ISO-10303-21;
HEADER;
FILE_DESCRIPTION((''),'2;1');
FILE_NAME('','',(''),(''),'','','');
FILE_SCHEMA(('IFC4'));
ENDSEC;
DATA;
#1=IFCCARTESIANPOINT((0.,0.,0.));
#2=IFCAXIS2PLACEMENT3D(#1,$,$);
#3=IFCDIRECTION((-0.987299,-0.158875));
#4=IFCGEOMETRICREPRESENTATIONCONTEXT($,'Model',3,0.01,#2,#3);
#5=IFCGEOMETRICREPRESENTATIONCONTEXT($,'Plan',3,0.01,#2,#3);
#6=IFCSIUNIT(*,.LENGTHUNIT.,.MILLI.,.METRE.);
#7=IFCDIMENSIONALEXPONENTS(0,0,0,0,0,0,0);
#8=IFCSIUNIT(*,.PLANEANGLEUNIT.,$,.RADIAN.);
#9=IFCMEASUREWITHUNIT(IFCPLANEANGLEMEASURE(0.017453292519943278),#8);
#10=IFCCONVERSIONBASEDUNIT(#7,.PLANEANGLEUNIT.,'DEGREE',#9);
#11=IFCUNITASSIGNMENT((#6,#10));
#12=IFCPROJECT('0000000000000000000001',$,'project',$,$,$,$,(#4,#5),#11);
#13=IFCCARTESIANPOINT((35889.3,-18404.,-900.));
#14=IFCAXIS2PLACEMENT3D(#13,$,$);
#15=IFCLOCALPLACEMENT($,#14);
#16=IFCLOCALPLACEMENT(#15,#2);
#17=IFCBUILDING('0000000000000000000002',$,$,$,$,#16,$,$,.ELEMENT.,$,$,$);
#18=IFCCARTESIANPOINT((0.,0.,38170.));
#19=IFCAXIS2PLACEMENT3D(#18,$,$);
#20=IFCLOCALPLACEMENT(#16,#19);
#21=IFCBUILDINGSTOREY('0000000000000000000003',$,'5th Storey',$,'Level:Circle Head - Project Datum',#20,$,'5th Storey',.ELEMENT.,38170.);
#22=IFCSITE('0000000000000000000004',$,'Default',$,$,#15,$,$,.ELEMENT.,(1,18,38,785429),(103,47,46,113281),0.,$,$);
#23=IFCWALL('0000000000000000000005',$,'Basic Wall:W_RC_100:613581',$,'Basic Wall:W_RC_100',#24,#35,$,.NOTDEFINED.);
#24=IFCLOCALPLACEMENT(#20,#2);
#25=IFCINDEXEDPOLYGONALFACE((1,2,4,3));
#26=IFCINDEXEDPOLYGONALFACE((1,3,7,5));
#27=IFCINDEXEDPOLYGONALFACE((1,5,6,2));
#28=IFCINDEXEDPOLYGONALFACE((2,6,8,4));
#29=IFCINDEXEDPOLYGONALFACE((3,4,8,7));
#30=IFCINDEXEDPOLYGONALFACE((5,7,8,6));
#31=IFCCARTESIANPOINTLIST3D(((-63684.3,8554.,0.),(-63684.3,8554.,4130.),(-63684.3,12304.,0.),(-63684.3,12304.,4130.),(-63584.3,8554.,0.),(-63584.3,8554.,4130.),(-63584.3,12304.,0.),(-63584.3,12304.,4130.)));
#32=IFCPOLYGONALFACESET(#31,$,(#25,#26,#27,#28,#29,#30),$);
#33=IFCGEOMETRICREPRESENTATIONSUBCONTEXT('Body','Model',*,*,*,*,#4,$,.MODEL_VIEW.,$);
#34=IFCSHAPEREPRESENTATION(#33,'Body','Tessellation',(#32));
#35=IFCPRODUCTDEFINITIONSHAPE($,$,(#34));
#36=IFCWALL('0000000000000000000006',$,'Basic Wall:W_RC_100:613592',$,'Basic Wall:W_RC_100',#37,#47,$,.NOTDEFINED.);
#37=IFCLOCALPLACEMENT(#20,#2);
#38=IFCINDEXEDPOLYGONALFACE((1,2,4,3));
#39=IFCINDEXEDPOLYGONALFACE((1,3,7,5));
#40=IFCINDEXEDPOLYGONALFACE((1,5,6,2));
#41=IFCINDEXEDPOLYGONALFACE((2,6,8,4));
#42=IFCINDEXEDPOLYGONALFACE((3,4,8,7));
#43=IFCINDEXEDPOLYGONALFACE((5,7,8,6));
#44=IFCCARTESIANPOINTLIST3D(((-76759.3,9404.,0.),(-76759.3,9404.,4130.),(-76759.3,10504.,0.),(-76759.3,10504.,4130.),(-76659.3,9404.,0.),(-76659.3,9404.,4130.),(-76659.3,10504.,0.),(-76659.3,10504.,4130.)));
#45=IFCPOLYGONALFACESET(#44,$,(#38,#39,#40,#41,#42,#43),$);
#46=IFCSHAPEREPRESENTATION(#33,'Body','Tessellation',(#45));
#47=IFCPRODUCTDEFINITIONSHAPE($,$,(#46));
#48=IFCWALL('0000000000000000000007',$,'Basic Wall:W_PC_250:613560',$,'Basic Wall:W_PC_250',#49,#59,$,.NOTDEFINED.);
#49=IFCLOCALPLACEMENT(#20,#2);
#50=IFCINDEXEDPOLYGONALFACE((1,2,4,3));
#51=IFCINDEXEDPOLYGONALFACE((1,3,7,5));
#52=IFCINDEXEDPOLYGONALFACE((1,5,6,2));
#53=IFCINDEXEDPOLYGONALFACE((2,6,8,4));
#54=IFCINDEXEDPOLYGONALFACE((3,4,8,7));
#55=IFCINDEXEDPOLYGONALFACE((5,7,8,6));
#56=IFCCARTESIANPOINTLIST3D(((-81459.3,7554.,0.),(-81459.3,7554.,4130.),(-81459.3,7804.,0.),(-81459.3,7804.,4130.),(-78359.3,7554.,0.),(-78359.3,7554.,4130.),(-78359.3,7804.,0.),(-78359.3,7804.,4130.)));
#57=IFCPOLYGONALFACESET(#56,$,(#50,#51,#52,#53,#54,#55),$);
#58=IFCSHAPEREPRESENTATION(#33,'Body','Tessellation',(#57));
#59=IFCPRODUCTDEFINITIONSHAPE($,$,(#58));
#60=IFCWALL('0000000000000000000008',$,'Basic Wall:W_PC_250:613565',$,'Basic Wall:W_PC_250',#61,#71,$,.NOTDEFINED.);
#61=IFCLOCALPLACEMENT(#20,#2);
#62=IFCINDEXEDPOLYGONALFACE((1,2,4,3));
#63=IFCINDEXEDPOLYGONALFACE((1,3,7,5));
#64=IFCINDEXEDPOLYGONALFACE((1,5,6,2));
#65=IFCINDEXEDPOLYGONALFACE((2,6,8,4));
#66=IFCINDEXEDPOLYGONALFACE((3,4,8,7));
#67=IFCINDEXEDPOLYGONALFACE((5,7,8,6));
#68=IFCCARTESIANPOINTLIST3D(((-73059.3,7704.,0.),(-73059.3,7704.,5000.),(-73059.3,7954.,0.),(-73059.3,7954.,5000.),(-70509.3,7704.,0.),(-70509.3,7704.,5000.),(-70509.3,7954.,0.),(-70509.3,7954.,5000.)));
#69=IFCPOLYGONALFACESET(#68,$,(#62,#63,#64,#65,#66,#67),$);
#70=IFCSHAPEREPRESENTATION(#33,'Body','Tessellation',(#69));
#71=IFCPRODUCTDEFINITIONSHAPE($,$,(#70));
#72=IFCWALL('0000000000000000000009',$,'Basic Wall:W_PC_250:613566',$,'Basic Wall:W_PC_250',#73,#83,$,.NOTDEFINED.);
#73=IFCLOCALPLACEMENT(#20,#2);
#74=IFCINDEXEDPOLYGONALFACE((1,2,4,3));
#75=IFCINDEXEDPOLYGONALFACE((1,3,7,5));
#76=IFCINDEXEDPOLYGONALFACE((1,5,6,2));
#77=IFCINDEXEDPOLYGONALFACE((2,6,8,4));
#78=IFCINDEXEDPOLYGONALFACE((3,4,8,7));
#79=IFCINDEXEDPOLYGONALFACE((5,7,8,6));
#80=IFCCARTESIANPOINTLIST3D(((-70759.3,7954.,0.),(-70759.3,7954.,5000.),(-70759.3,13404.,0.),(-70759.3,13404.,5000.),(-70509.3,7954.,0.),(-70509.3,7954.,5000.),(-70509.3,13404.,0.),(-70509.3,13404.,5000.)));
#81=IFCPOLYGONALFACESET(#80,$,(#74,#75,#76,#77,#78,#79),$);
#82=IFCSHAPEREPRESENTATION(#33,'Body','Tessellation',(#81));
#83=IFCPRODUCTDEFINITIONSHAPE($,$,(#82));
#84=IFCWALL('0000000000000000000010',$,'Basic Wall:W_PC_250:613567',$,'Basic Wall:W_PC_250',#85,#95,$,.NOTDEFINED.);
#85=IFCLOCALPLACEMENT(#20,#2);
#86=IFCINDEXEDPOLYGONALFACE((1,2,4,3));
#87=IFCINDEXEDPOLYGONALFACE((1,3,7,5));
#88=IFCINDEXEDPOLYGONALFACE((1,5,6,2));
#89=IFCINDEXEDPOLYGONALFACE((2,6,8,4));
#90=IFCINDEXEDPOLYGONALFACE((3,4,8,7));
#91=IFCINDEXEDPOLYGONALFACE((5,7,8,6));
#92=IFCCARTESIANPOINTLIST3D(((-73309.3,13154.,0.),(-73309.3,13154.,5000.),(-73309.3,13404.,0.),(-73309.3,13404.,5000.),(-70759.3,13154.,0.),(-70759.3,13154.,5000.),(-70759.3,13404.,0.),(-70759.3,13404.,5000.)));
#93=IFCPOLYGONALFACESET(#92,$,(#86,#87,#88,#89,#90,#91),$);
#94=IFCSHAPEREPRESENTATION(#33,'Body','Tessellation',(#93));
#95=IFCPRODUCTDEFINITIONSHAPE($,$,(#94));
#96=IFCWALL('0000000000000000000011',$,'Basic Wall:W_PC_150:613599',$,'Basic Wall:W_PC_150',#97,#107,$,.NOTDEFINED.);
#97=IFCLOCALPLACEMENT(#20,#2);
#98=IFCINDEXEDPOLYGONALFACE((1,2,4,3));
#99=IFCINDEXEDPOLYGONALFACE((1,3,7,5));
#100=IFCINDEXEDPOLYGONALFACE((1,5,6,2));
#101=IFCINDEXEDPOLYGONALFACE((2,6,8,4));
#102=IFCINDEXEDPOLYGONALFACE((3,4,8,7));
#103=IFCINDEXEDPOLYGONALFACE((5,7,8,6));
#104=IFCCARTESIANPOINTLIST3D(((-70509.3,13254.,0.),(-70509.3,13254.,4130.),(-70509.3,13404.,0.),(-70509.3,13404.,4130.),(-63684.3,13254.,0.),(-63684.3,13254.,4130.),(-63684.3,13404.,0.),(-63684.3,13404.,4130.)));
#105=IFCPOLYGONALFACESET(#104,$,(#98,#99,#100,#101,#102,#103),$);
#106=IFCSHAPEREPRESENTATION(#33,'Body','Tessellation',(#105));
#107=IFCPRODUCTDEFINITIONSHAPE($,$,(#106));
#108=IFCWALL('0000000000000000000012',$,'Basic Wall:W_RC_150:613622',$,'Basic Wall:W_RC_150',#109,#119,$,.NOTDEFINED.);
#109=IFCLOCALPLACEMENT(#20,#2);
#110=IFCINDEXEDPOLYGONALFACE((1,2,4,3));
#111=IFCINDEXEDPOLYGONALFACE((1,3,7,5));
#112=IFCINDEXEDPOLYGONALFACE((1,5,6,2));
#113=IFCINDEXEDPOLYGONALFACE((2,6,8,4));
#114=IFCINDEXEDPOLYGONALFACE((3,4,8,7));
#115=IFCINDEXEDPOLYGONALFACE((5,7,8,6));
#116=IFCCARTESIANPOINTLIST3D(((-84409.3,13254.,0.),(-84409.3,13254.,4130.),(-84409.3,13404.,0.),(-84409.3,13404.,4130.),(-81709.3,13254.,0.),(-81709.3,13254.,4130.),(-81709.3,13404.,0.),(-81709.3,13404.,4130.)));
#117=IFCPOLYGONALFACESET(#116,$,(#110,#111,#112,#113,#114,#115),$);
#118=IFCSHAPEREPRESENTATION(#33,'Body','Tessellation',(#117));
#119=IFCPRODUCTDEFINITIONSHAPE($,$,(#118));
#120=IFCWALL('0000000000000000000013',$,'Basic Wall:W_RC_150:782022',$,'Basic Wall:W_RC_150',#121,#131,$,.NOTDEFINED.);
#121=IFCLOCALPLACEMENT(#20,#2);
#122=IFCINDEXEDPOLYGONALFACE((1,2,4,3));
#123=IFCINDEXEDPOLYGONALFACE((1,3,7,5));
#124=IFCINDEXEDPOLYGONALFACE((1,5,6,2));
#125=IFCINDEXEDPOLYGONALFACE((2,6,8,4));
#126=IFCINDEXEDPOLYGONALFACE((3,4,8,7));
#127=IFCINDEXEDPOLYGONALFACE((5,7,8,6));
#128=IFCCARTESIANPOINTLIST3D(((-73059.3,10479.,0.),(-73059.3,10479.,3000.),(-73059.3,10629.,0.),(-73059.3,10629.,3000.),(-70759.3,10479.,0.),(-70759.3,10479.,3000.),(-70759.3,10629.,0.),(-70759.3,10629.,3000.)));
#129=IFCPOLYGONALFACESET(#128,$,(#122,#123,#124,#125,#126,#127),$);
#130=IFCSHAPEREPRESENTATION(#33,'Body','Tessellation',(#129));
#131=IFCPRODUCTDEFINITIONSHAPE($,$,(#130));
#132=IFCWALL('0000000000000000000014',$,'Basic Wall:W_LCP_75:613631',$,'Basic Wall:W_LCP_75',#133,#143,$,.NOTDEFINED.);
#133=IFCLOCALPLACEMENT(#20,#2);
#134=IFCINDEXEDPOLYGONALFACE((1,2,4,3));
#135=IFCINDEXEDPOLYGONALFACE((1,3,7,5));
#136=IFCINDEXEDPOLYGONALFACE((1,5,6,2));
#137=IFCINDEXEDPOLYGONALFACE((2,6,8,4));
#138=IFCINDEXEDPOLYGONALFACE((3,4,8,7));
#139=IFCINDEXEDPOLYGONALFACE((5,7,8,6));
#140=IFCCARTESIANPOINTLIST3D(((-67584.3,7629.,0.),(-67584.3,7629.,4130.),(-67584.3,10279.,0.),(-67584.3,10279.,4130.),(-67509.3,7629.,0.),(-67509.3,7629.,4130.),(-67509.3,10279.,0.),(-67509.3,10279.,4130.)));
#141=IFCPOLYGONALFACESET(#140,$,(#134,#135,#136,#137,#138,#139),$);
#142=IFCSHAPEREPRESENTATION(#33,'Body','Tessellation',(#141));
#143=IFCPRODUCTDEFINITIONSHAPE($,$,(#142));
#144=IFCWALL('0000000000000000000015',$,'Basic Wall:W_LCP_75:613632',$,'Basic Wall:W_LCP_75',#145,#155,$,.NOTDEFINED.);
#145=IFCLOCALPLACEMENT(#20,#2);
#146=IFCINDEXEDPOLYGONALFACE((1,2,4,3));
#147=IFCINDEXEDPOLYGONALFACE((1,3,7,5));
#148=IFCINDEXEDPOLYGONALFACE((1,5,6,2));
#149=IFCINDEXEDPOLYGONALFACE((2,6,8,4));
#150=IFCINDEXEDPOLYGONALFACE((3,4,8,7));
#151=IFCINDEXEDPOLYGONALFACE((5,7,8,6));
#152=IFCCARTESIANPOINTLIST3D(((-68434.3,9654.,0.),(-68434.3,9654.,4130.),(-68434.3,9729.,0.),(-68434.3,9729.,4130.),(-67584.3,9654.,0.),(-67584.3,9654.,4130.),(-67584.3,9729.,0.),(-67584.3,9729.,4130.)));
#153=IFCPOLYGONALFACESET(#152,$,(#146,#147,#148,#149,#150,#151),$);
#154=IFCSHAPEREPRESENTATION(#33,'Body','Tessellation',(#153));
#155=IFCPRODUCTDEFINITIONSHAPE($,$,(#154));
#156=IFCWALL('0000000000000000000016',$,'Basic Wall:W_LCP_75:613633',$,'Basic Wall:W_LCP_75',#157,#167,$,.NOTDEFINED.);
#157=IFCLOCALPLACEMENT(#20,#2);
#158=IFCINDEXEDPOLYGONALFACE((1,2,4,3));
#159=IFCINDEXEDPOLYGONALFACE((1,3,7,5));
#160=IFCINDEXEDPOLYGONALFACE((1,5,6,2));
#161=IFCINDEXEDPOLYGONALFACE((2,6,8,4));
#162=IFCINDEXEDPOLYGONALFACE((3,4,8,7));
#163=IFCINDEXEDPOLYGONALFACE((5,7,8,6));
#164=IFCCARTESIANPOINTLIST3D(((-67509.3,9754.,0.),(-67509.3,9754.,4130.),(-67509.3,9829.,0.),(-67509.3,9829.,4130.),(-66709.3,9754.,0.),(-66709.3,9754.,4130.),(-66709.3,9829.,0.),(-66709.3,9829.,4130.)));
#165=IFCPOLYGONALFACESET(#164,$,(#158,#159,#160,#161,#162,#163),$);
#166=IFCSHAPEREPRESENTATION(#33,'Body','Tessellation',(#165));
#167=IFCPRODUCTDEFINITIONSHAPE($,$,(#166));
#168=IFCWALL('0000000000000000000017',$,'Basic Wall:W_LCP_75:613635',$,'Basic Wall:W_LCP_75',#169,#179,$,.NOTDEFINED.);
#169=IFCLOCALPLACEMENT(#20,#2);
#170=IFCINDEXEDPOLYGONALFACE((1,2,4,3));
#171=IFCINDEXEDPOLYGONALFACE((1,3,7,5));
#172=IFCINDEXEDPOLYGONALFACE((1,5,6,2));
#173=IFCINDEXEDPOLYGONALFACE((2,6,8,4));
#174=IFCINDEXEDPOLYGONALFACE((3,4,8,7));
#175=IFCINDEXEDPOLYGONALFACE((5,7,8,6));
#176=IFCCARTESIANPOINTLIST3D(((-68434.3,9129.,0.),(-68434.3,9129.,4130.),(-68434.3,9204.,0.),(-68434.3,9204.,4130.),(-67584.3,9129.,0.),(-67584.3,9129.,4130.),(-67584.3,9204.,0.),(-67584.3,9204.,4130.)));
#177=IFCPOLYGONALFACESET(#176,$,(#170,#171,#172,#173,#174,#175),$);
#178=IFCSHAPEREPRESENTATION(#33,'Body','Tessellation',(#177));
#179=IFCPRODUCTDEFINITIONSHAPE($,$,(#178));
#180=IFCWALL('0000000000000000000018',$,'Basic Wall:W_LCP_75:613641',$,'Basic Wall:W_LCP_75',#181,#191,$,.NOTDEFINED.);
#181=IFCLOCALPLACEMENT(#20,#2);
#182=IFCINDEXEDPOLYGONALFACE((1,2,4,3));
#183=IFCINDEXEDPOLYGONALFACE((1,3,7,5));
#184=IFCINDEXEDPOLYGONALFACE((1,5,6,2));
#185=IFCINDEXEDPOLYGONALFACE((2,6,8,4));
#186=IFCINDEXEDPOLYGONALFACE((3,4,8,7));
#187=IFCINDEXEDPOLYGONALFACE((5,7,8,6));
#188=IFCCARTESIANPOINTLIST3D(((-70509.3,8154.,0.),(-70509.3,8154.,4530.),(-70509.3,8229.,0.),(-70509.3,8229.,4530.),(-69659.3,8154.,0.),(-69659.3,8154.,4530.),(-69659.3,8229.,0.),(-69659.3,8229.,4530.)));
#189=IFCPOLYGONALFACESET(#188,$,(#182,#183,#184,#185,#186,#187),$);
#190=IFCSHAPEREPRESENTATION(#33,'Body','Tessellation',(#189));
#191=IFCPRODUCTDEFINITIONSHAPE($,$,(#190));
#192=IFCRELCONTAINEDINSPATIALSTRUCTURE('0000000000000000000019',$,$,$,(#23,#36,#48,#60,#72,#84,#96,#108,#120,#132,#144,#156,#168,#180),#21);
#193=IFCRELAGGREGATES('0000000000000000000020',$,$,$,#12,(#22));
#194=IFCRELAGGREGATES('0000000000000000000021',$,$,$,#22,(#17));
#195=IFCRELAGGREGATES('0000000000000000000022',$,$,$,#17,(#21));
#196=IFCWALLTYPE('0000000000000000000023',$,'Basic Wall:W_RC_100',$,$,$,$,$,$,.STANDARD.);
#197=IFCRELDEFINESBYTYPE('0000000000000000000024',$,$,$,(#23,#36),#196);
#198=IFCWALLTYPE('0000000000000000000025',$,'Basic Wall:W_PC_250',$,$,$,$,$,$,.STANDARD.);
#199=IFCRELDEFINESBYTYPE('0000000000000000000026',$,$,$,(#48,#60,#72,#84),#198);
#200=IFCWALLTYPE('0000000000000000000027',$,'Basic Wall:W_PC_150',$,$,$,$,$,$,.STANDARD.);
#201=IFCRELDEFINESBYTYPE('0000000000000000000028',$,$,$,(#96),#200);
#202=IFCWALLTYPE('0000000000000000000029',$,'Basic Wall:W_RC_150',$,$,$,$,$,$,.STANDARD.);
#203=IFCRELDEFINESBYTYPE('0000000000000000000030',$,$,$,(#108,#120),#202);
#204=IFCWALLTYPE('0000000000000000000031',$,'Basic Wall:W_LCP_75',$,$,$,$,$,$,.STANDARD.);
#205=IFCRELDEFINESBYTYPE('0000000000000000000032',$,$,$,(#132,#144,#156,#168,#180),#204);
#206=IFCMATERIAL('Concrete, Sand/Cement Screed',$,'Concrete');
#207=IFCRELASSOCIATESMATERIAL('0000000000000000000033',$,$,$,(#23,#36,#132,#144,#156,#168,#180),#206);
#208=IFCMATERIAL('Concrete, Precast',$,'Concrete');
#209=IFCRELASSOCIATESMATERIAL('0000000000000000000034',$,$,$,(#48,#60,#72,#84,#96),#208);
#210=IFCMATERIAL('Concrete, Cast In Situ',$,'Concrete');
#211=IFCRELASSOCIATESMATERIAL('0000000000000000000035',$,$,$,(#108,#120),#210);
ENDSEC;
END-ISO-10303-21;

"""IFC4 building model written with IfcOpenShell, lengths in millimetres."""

from ifc_helpers import new_model, entity, si_unit, converted_unit, direction, frame, origin, place, context, subcontext, project, spatial, indexed_curve, outline, extrude, material, type_object, element, save


model = new_model("IFC4")

# Units and contexts
model_context = context("Model", 3, precision=0.01, world=origin(), true_north=direction((-0.987299, -0.158875)))
plan_context = context("Plan", 3, precision=0.01, world=origin(), true_north=direction((-0.987299, -0.158875)))
body_context = subcontext(model_context, "Body", "Model", "MODEL_VIEW")
ifc_project = project(units=[si_unit("LENGTHUNIT", "METRE", prefix="MILLI"), converted_unit("PLANEANGLEUNIT", "DEGREE", entity("IfcPlaneAngleMeasure", 0.017453292519943278), si_unit("PLANEANGLEUNIT", "RADIAN"), dimensions=[0, 0, 0, 0, 0, 0, 0])], contexts=[model_context, plan_context])

# Site, building, storey
site_placement = place(None, frame((35889.3, -18404.0, -900.0)))
site = spatial("IfcSite", under=ifc_project, at=site_placement, Name="Default", CompositionType="ELEMENT", RefLatitude=(1, 18, 38, 785429), RefLongitude=(103, 47, 46, 113281), RefElevation=0.0)
building_placement = place(site_placement, origin())
building = spatial("IfcBuilding", under=site, at=building_placement, CompositionType="ELEMENT")
storey_placement = place(building_placement, frame((0.0, 0.0, 38170.0)))
storey = spatial("IfcBuildingStorey", under=building, at=storey_placement, Name="5th Storey", ObjectType="Level:Circle Head - Project Datum", LongName="5th Storey", CompositionType="ELEMENT", Elevation=38170.0)

# Walls
ifc_material_1 = material(Name="Concrete, Sand/Cement Screed", Category="Concrete")
wall_type_1 = type_object("IfcWallType", Name="Basic Wall:W_RC_100", PredefinedType="STANDARD")
wall_1_placement = place(storey_placement, frame((-63634.3, 12304.0, 0.0), z_axis=(0.0, 0.0, 1.0), x_axis=(0.0, -1.0, 0.0)))
element("IfcWall", 1, at=wall_1_placement, inside=storey, type_object=wall_type_1, material=ifc_material_1, Name="Basic Wall:W_RC_100:613581", ObjectType="Basic Wall:W_RC_100", PredefinedType="NOTDEFINED", context=body_context, shape_type="SweptSolid", body=[
    extrude(outline(indexed_curve([(3750.0, 50.0), (0.0, 50.0), (0.0, -50.0), (3750.0, -50.0), (3750.0, 50.0)], self_intersect=False)), origin(), (0.0, 0.0, 1.0), 4130.0),
])
wall_2_placement = place(storey_placement, frame((-76709.3, 10504.0, 0.0), z_axis=(0.0, 0.0, 1.0), x_axis=(0.0, -1.0, 0.0)))
element("IfcWall", 2, at=wall_2_placement, inside=storey, type_object=wall_type_1, material=ifc_material_1, Name="Basic Wall:W_RC_100:613592", ObjectType="Basic Wall:W_RC_100", PredefinedType="NOTDEFINED", context=body_context, shape_type="SweptSolid", body=[
    extrude(outline(indexed_curve([(1100.0, 50.0), (0.0, 50.0), (0.0, -50.0), (1100.0, -50.0), (1100.0, 50.0)], self_intersect=False)), origin(), (0.0, 0.0, 1.0), 4130.0),
])
ifc_material_2 = material(Name="Concrete, Precast", Category="Concrete")
wall_type_2 = type_object("IfcWallType", Name="Basic Wall:W_PC_250", PredefinedType="STANDARD")
wall_3_placement = place(storey_placement, frame((-81459.3, 7679.0, 0.0)))
element("IfcWall", 3, at=wall_3_placement, inside=storey, type_object=wall_type_2, material=ifc_material_2, Name="Basic Wall:W_PC_250:613560", ObjectType="Basic Wall:W_PC_250", PredefinedType="NOTDEFINED", context=body_context, shape_type="SweptSolid", body=[
    extrude(outline(indexed_curve([(3100.0, 125.0), (0.0, 125.0), (0.0, -125.0), (3100.0, -125.0), (3100.0, 125.0)], self_intersect=False)), origin(), (0.0, 0.0, 1.0), 4130.0),
])
wall_4_placement = place(storey_placement, frame((-73059.3, 7829.0, 0.0)))
element("IfcWall", 4, at=wall_4_placement, inside=storey, type_object=wall_type_2, material=ifc_material_2, Name="Basic Wall:W_PC_250:613565", ObjectType="Basic Wall:W_PC_250", PredefinedType="NOTDEFINED", context=body_context, shape_type="SweptSolid", body=[
    extrude(outline(indexed_curve([(2550.0, 125.0), (0.0, 125.0), (0.0, -125.0), (2550.0, -125.0), (2550.0, 125.0)], self_intersect=False)), origin(), (0.0, 0.0, 1.0), 5000.0),
])
wall_5_placement = place(storey_placement, frame((-70634.3, 7954.0, 0.0), z_axis=(0.0, 0.0, 1.0), x_axis=(0.0, 1.0, 0.0)))
element("IfcWall", 5, at=wall_5_placement, inside=storey, type_object=wall_type_2, material=ifc_material_2, Name="Basic Wall:W_PC_250:613566", ObjectType="Basic Wall:W_PC_250", PredefinedType="NOTDEFINED", context=body_context, shape_type="SweptSolid", body=[
    extrude(outline(indexed_curve([(5450.0, 125.0), (0.0, 125.0), (0.0, -125.0), (5450.0, -125.0), (5450.0, 125.0)], self_intersect=False)), origin(), (0.0, 0.0, 1.0), 5000.0),
])
wall_6_placement = place(storey_placement, frame((-73309.3, 13279.0, 0.0)))
element("IfcWall", 6, at=wall_6_placement, inside=storey, type_object=wall_type_2, material=ifc_material_2, Name="Basic Wall:W_PC_250:613567", ObjectType="Basic Wall:W_PC_250", PredefinedType="NOTDEFINED", context=body_context, shape_type="SweptSolid", body=[
    extrude(outline(indexed_curve([(2550.0, 125.0), (0.0, 125.0), (0.0, -125.0), (2550.0, -125.0), (2550.0, 125.0)], self_intersect=False)), origin(), (0.0, 0.0, 1.0), 5000.0),
])
wall_type_3 = type_object("IfcWallType", Name="Basic Wall:W_PC_150", PredefinedType="STANDARD")
wall_7_placement = place(storey_placement, frame((-70509.3, 13329.0, 0.0)))
element("IfcWall", 7, at=wall_7_placement, inside=storey, type_object=wall_type_3, material=ifc_material_2, Name="Basic Wall:W_PC_150:613599", ObjectType="Basic Wall:W_PC_150", PredefinedType="NOTDEFINED", context=body_context, shape_type="SweptSolid", body=[
    extrude(outline(indexed_curve([(6825.0, 75.0), (0.0, 75.0), (0.0, -75.0), (6825.0, -75.0), (6825.0, 75.0)], self_intersect=False)), origin(), (0.0, 0.0, 1.0), 4130.0),
])
ifc_material_3 = material(Name="Concrete, Cast In Situ", Category="Concrete")
wall_type_4 = type_object("IfcWallType", Name="Basic Wall:W_RC_150", PredefinedType="STANDARD")
wall_8_placement = place(storey_placement, frame((-81709.3, 13329.0, 0.0), z_axis=(0.0, 0.0, 1.0), x_axis=(-1.0, 0.0, 0.0)))
element("IfcWall", 8, at=wall_8_placement, inside=storey, type_object=wall_type_4, material=ifc_material_3, Name="Basic Wall:W_RC_150:613622", ObjectType="Basic Wall:W_RC_150", PredefinedType="NOTDEFINED", context=body_context, shape_type="SweptSolid", body=[
    extrude(outline(indexed_curve([(2700.0, 75.0), (0.0, 75.0), (0.0, -75.0), (2700.0, -75.0), (2700.0, 75.0)], self_intersect=False)), origin(), (0.0, 0.0, 1.0), 4130.0),
])
wall_9_placement = place(storey_placement, frame((-70759.3, 10554.0, 0.0), z_axis=(0.0, 0.0, 1.0), x_axis=(-1.0, 0.0, 0.0)))
element("IfcWall", 9, at=wall_9_placement, inside=storey, type_object=wall_type_4, material=ifc_material_3, Name="Basic Wall:W_RC_150:782022", ObjectType="Basic Wall:W_RC_150", PredefinedType="NOTDEFINED", context=body_context, shape_type="SweptSolid", body=[
    extrude(outline(indexed_curve([(2300.0, 75.0), (0.0, 75.0), (0.0, -75.0), (2300.0, -75.0), (2300.0, 75.0)], self_intersect=False)), origin(), (0.0, 0.0, 1.0), 3000.0),
])
wall_type_5 = type_object("IfcWallType", Name="Basic Wall:W_LCP_75", PredefinedType="STANDARD")
wall_10_placement = place(storey_placement, frame((-67546.8, 10279.0, 0.0), z_axis=(0.0, 0.0, 1.0), x_axis=(0.0, -1.0, 0.0)))
element("IfcWall", 10, at=wall_10_placement, inside=storey, type_object=wall_type_5, material=ifc_material_1, Name="Basic Wall:W_LCP_75:613631", ObjectType="Basic Wall:W_LCP_75", PredefinedType="NOTDEFINED", context=body_context, shape_type="SweptSolid", body=[
    extrude(outline(indexed_curve([(2650.0, 37.5), (0.0, 37.5), (0.0, -37.5), (2650.0, -37.5), (2650.0, 37.5)], self_intersect=False)), origin(), (0.0, 0.0, 1.0), 4130.0),
])
wall_11_placement = place(storey_placement, frame((-68434.3, 9691.5, 0.0)))
element("IfcWall", 11, at=wall_11_placement, inside=storey, type_object=wall_type_5, material=ifc_material_1, Name="Basic Wall:W_LCP_75:613632", ObjectType="Basic Wall:W_LCP_75", PredefinedType="NOTDEFINED", context=body_context, shape_type="SweptSolid", body=[
    extrude(outline(indexed_curve([(850.0, 37.5), (0.0, 37.5), (0.0, -37.5), (850.0, -37.5), (850.0, 37.5)], self_intersect=False)), origin(), (0.0, 0.0, 1.0), 4130.0),
])
wall_12_placement = place(storey_placement, frame((-67509.3, 9791.5, 0.0)))
element("IfcWall", 12, at=wall_12_placement, inside=storey, type_object=wall_type_5, material=ifc_material_1, Name="Basic Wall:W_LCP_75:613633", ObjectType="Basic Wall:W_LCP_75", PredefinedType="NOTDEFINED", context=body_context, shape_type="SweptSolid", body=[
    extrude(outline(indexed_curve([(800.0, 37.5), (0.0, 37.5), (0.0, -37.5), (800.0, -37.5), (800.0, 37.5)], self_intersect=False)), origin(), (0.0, 0.0, 1.0), 4130.0),
])
wall_13_placement = place(storey_placement, frame((-68434.3, 9166.5, 0.0)))
element("IfcWall", 13, at=wall_13_placement, inside=storey, type_object=wall_type_5, material=ifc_material_1, Name="Basic Wall:W_LCP_75:613635", ObjectType="Basic Wall:W_LCP_75", PredefinedType="NOTDEFINED", context=body_context, shape_type="SweptSolid", body=[
    extrude(outline(indexed_curve([(850.0, 37.5), (0.0, 37.5), (0.0, -37.5), (850.0, -37.5), (850.0, 37.5)], self_intersect=False)), origin(), (0.0, 0.0, 1.0), 4130.0),
])
wall_14_placement = place(storey_placement, frame((-70509.3, 8191.5, 0.0)))
element("IfcWall", 14, at=wall_14_placement, inside=storey, type_object=wall_type_5, material=ifc_material_1, Name="Basic Wall:W_LCP_75:613641", ObjectType="Basic Wall:W_LCP_75", PredefinedType="NOTDEFINED", context=body_context, shape_type="SweptSolid", body=[
    extrude(outline(indexed_curve([(850.0, 37.5), (0.0, 37.5), (0.0, -37.5), (850.0, -37.5), (850.0, 37.5)], self_intersect=False)), origin(), (0.0, 0.0, 1.0), 4530.0),
])

save(model, "model.ifc")
